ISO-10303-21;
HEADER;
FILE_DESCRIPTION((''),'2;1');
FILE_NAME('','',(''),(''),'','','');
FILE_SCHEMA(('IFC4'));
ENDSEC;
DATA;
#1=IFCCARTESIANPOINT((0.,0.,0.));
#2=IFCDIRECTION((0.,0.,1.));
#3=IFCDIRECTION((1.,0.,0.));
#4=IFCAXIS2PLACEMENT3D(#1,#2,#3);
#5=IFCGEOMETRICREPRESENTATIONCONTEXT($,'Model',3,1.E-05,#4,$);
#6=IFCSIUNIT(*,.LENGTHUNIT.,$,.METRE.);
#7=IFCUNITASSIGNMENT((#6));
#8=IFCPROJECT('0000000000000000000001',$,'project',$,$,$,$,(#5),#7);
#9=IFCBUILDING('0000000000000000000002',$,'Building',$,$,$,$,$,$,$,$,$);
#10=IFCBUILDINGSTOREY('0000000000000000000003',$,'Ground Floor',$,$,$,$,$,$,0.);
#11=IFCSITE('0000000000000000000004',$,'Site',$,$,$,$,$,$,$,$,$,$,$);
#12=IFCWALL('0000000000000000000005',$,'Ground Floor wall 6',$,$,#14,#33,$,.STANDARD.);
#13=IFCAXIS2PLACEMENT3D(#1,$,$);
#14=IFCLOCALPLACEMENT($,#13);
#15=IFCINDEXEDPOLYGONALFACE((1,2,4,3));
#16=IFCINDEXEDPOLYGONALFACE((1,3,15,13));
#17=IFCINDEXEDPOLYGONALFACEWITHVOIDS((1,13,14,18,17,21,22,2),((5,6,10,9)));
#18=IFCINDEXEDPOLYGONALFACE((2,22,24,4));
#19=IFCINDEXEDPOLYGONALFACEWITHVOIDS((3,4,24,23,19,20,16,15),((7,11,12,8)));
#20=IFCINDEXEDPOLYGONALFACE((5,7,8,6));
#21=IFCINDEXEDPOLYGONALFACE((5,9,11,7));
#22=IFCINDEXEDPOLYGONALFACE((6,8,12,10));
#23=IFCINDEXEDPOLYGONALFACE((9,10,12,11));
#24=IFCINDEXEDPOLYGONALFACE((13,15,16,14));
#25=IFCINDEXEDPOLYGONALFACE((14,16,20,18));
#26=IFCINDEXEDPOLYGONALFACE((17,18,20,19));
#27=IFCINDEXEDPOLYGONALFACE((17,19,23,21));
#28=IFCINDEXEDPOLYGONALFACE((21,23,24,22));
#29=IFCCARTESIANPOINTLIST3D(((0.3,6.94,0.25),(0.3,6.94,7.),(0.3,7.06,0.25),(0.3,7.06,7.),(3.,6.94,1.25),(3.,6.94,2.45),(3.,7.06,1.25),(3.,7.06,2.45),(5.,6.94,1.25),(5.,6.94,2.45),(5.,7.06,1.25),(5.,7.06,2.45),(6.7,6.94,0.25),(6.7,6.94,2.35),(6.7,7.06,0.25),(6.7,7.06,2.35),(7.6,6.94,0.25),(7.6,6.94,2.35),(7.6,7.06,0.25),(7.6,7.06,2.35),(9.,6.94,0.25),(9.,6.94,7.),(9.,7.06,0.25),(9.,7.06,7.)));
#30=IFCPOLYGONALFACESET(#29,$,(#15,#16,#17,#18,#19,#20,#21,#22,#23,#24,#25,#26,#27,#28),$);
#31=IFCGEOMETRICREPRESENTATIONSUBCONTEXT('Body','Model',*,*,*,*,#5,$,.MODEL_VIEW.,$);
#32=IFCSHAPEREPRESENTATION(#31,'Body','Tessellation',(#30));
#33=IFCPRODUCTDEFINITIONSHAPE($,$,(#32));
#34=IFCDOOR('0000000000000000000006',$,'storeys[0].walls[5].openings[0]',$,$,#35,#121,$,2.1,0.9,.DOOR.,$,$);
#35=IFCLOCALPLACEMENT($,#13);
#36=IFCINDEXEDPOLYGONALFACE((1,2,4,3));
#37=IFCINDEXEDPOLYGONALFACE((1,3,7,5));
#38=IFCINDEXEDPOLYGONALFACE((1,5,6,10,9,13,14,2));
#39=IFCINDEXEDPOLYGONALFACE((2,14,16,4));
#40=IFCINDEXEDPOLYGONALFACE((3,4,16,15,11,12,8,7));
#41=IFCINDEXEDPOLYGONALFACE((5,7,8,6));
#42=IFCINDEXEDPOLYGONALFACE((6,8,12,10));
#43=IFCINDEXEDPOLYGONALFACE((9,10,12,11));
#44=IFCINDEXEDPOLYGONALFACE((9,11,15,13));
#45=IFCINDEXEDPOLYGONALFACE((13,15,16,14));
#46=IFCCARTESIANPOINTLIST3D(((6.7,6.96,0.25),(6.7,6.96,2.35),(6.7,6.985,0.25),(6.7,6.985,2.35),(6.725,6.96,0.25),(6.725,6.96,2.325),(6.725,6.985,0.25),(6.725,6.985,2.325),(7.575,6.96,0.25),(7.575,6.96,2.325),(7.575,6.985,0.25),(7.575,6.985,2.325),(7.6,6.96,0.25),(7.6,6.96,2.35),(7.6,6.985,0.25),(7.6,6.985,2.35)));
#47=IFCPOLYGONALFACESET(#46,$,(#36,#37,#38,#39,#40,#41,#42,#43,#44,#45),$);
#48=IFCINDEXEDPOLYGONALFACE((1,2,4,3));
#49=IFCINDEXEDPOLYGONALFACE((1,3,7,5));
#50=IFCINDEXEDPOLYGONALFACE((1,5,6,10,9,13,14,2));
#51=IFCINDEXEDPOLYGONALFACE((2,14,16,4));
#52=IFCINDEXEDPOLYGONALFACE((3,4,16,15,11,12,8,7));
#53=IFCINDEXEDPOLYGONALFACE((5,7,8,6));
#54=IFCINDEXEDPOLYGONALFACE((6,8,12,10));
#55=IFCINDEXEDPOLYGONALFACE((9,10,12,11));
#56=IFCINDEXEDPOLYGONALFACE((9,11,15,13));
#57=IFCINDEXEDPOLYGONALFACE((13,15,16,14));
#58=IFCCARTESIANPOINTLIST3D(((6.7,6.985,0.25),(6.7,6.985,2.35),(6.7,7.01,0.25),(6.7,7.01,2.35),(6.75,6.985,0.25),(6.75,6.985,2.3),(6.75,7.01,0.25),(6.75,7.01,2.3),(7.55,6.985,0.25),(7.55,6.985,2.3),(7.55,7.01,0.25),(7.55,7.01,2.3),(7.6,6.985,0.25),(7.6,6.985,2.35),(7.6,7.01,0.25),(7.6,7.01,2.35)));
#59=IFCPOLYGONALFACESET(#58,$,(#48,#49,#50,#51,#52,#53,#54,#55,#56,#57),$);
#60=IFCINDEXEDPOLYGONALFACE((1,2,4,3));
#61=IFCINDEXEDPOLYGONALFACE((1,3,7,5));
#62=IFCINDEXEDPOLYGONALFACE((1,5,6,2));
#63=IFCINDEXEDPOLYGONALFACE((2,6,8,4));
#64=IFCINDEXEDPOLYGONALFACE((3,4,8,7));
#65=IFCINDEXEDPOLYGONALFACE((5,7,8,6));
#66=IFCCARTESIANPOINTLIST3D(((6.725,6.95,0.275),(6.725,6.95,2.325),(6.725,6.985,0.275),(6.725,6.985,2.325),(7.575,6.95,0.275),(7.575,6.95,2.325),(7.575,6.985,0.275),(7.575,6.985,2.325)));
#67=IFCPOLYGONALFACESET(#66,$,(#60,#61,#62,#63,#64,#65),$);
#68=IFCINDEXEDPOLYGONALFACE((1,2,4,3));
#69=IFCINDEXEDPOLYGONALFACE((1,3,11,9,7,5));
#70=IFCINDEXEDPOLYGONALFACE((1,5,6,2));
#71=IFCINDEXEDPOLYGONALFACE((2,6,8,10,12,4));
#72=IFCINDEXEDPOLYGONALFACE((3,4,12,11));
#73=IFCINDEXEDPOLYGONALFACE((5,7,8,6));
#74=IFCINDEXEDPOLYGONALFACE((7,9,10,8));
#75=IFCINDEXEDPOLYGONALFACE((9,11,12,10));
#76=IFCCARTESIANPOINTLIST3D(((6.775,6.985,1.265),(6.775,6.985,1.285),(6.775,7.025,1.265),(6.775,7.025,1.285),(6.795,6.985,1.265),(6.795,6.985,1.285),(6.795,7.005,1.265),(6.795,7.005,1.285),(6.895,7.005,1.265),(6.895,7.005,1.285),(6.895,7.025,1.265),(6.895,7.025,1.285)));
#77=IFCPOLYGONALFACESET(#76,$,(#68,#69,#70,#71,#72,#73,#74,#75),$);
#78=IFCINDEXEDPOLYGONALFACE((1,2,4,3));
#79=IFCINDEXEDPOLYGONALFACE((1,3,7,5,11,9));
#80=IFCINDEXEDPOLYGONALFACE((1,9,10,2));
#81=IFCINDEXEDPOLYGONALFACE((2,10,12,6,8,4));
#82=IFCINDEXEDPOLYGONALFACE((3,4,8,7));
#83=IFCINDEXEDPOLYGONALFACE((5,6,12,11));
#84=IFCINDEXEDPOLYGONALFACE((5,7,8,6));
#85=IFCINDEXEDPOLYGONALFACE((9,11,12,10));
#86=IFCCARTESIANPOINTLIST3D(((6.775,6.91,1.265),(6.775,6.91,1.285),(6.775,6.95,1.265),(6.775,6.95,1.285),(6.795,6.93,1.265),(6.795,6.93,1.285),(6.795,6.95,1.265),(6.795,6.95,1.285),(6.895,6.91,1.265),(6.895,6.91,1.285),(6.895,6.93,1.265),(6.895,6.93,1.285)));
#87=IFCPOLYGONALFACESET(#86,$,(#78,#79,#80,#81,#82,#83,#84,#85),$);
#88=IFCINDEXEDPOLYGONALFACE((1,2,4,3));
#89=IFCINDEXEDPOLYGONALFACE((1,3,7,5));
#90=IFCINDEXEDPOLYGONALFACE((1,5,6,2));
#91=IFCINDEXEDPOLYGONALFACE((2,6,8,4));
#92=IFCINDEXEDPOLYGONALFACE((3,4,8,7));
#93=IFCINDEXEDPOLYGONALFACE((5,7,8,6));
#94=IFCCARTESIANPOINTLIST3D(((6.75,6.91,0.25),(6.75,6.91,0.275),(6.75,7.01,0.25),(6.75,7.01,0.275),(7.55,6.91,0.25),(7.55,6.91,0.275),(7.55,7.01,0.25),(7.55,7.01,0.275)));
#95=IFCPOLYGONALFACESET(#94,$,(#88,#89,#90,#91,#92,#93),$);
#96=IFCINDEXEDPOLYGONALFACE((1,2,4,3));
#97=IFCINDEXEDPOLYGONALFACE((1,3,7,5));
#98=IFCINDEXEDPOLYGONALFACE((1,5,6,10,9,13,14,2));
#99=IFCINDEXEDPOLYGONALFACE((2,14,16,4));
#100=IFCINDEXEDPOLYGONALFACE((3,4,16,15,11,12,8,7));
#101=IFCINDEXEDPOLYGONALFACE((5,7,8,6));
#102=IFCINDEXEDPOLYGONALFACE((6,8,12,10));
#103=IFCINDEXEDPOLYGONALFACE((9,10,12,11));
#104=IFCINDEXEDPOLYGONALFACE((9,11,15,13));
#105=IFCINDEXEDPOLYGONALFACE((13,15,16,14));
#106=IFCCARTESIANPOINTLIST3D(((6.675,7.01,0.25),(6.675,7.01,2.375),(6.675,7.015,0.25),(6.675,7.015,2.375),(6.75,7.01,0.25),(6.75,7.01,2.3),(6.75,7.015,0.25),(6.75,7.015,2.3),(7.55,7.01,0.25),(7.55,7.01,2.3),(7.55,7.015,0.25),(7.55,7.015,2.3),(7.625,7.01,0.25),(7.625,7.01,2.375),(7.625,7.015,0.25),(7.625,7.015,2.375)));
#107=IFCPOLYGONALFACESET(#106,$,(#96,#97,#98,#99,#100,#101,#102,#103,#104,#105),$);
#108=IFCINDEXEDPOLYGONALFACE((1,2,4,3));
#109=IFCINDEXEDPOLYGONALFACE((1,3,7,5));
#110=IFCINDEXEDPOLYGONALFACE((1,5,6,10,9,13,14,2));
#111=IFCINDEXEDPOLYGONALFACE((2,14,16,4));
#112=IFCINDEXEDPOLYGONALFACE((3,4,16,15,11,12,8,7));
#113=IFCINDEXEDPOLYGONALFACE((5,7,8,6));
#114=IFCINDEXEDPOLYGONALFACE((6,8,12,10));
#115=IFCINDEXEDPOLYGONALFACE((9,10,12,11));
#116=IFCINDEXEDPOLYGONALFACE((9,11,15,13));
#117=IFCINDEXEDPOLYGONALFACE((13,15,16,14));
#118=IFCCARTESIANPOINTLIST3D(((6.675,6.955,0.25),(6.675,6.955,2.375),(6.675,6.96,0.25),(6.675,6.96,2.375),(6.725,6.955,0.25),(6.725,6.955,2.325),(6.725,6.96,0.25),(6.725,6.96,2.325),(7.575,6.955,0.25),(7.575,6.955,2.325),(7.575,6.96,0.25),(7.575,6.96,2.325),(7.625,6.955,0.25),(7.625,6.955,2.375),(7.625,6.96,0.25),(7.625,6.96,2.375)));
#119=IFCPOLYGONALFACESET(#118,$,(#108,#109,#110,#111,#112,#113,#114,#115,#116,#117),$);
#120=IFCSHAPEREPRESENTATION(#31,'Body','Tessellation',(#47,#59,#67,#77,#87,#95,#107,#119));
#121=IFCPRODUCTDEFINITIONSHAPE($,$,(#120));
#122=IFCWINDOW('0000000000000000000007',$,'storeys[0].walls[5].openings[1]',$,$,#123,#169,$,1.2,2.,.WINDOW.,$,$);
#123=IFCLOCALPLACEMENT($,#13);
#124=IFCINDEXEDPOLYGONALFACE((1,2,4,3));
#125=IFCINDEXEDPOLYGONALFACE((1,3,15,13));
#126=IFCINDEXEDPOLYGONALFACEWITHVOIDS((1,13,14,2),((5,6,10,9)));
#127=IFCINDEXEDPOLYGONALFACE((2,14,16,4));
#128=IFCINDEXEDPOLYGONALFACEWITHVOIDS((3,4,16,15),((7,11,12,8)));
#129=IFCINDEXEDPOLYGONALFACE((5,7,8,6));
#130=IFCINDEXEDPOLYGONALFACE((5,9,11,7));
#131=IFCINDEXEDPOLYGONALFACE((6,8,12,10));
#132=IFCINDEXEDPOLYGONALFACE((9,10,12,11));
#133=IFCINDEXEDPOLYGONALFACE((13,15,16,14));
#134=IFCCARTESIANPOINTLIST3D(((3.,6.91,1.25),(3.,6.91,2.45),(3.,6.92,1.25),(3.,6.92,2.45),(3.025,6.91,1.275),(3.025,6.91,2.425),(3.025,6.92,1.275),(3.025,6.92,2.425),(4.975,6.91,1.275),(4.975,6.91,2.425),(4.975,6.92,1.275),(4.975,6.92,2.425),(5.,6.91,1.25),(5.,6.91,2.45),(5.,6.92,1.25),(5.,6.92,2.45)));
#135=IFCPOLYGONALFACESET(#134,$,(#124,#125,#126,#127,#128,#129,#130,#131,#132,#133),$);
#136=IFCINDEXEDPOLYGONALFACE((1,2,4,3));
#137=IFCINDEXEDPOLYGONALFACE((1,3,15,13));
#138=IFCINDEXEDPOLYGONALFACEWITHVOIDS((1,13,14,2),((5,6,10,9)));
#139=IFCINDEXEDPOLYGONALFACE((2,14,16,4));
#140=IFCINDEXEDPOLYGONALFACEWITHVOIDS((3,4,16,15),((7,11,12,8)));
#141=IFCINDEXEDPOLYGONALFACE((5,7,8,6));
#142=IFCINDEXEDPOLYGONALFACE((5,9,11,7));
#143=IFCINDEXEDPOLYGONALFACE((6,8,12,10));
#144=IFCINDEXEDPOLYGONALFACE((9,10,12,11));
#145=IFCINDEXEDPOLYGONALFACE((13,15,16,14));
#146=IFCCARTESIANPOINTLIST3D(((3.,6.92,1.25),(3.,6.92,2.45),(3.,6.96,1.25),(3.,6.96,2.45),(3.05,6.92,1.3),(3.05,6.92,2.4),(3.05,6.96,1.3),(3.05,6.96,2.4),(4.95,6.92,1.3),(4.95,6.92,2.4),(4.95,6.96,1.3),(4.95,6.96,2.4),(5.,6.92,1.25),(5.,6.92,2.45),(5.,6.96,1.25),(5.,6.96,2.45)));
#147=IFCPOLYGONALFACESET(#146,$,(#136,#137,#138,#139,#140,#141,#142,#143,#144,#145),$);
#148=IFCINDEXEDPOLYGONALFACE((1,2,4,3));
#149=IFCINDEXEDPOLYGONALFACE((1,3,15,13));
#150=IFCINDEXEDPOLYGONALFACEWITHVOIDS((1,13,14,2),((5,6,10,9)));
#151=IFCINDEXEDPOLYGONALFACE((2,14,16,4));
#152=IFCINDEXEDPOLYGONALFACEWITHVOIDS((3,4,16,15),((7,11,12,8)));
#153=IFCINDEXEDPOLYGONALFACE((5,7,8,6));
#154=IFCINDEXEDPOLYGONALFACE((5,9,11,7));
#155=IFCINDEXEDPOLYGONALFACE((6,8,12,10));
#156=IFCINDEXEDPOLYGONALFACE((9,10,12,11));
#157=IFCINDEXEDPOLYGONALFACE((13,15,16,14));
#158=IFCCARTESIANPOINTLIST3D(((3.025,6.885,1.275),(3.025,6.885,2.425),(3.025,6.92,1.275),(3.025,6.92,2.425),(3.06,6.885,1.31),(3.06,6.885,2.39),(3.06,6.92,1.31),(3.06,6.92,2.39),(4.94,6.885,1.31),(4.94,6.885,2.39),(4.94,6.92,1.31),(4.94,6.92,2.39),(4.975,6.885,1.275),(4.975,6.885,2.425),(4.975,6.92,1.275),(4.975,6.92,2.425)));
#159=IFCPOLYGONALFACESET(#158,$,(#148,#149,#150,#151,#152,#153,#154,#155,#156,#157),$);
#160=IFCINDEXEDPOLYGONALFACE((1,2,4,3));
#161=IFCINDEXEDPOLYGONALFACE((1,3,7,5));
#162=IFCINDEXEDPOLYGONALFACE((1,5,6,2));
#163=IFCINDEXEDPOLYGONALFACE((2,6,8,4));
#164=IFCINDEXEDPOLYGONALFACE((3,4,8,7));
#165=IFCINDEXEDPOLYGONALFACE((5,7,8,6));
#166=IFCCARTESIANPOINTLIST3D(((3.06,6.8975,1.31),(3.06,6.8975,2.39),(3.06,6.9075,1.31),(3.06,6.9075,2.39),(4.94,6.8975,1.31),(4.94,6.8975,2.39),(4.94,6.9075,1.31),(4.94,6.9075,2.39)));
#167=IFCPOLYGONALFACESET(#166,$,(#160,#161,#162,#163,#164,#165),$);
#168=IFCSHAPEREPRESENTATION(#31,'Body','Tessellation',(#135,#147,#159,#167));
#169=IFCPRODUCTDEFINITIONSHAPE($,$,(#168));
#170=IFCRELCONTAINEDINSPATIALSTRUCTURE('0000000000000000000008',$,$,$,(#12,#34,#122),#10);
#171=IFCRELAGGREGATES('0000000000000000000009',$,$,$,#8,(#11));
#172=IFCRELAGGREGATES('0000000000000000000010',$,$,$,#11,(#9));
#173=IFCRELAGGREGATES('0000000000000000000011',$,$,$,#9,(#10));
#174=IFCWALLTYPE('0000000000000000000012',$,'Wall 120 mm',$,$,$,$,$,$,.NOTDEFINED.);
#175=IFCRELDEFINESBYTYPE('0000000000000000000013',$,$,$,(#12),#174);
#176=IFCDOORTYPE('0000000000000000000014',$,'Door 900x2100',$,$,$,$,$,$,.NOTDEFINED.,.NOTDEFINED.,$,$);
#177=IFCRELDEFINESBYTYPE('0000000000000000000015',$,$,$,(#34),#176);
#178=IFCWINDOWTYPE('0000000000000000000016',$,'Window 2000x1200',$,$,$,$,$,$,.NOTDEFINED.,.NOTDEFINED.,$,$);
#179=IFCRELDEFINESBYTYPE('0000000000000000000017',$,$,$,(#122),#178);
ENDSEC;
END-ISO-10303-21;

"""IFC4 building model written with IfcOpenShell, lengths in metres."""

from ifc_helpers import new_model, si_unit, frame, origin_with_axes, place, context, subcontext, project, spatial, line, indexed_curve, outline, extrude, type_object, element, fill, save


model = new_model("IFC4")

# Units and contexts
model_context = context("Model", 3, precision=1e-05, world=origin_with_axes())
body_context = subcontext(model_context, "Body", "Model", "MODEL_VIEW")
ifc_project = project(units=[si_unit("LENGTHUNIT", "METRE")], contexts=[model_context])

# Site, building, storey
site = spatial("IfcSite", under=ifc_project, Name="Site")
building = spatial("IfcBuilding", under=site, Name="Building")
storey = spatial("IfcBuildingStorey", under=building, Name="Ground Floor", Elevation=0.0)

# Shared definitions
wall_type_1 = type_object("IfcWallType", Name="Wall 120 mm", PredefinedType="NOTDEFINED")
door_type_1 = type_object("IfcDoorType", Name="Door 900x2100", OperationType="NOTDEFINED", PredefinedType="NOTDEFINED")

# Wall, openings, door, window
wall_1_placement = place(None, frame((9.0, 7.0, 0.25), z_axis=(0.0, 0.0, 1.0), x_axis=(-1.0, 0.0, 0.0)))
wall_1 = element("IfcWall", 1, at=wall_1_placement, inside=storey, type_object=wall_type_1, Name="Ground Floor wall 6", PredefinedType="STANDARD", context=body_context, shape_type="SweptSolid", body=[
    extrude(outline(indexed_curve([(0.0, 0.0), (0.0, 0.12), (8.7, 0.12), (8.7, 0.0), (0.0, 0.0)], self_intersect=False)), frame((0.0, -0.06, 0.0), z_axis=(0.0, 0.0, 1.0), x_axis=(1.0, 0.0, 0.0)), (0.0, 0.0, 1.0), 6.75),
])
opening_1_placement = place(wall_1_placement, frame((1.4, -0.07, 0.0), z_axis=(0.0, 0.0, 1.0), x_axis=(1.0, 0.0, 0.0)))
opening_1 = element("IfcOpeningElement", 2, at=opening_1_placement, cuts=wall_1, context=body_context, shape_type="SweptSolid", body=[
    extrude(outline(indexed_curve([(0.0, 0.0), (0.0, 0.14), (0.9, 0.14), (0.9, 0.0), (0.0, 0.0)], self_intersect=False)), origin_with_axes(), (0.0, 0.0, 1.0), 2.1),
])
opening_2_placement = place(wall_1_placement, frame((4.0, -0.07, 1.0), z_axis=(0.0, 0.0, 1.0), x_axis=(1.0, 0.0, 0.0)))
opening_2 = element("IfcOpeningElement", 3, at=opening_2_placement, cuts=wall_1, context=body_context, shape_type="SweptSolid", body=[
    extrude(outline(indexed_curve([(0.0, 0.0), (0.0, 0.14), (2.0, 0.14), (2.0, 0.0), (0.0, 0.0)], self_intersect=False)), origin_with_axes(), (0.0, 0.0, 1.0), 1.2),
])
door_1_placement = place(None, frame((7.6, 7.01, 0.25), z_axis=(0.0, 0.0, 1.0), x_axis=(-1.0, 0.0, 0.0)))
door_1 = element("IfcDoor", 4, at=door_1_placement, inside=storey, type_object=door_type_1, Name="storeys[0].walls[5].openings[0]", OverallHeight=2.1, OverallWidth=0.9, PredefinedType="DOOR", context=body_context, shape_type="SweptSolid", body=[
    extrude(outline(indexed_curve([(0.0, 0.0), (0.0, 2.1), (0.9, 2.1), (0.9, 0.0), (0.875, 0.0), (0.875, 2.075), (0.025, 2.075), (0.025, 0.0)], segments=[line(1, 2, 3, 4, 5, 6, 7, 8, 1)])), frame((0.0, 0.025, 0.0), z_axis=(0.0, -1.0, 0.0), x_axis=(1.0, 0.0, 0.0)), (0.0, 0.0, -1.0), 0.025),
    extrude(outline(indexed_curve([(0.0, 0.0), (0.0, 2.1), (0.9, 2.1), (0.9, 0.0), (0.85, 0.0), (0.85, 2.05), (0.05, 2.05), (0.05, 0.0)], segments=[line(1, 2, 3, 4, 5, 6, 7, 8, 1)])), frame((0.0, 0.0, 0.0), z_axis=(0.0, -1.0, 0.0), x_axis=(1.0, 0.0, 0.0)), (0.0, 0.0, -1.0), 0.025),
    extrude(outline(indexed_curve([(0.0, 0.0), (0.85, 0.0), (0.85, 0.035), (0.0, 0.035)], segments=[line(1, 2, 3, 4, 1)])), frame((0.025, 0.025, 0.025), z_axis=(0.0, 0.0, 1.0), x_axis=(1.0, 0.0, 0.0)), (0.0, 0.0, 1.0), 2.05),
    extrude(outline(indexed_curve([(0.0, 0.0), (0.0, -0.04), (-0.12, -0.04), (-0.12, -0.02), (-0.02, -0.02), (-0.02, 0.0)], segments=[line(1, 2, 3, 4, 5, 6, 1)])), frame((0.825, 0.025, 1.015), z_axis=(0.0, 0.0, 1.0), x_axis=(1.0, 0.0, 0.0)), (0.0, 0.0, 1.0), 0.02),
    extrude(outline(indexed_curve([(0.0, 0.0), (0.0, 0.04), (-0.12, 0.04), (-0.12, 0.02), (-0.02, 0.02), (-0.02, 0.0)], segments=[line(1, 2, 3, 4, 5, 6, 1)])), frame((0.825, 0.06, 1.015), z_axis=(0.0, 0.0, 1.0), x_axis=(1.0, 0.0, 0.0)), (0.0, 0.0, 1.0), 0.02),
    extrude(outline(indexed_curve([(0.0, 0.0), (0.8, 0.0), (0.8, 0.1), (0.0, 0.1)], segments=[line(1, 2, 3, 4, 1)])), frame((0.05, 0.0, 0.0), z_axis=(0.0, 0.0, 1.0), x_axis=(1.0, 0.0, 0.0)), (0.0, 0.0, 1.0), 0.025),
    extrude(outline(indexed_curve([(0.0, 0.0), (0.0, 2.125), (0.95, 2.125), (0.95, 0.0), (0.875, 0.0), (0.875, 2.05), (0.075, 2.05), (0.075, 0.0)], segments=[line(1, 2, 3, 4, 5, 6, 7, 8, 1)])), frame((-0.025, -0.005, 0.0), z_axis=(0.0, -1.0, 0.0), x_axis=(1.0, 0.0, 0.0)), (0.0, 0.0, -1.0), 0.005),
    extrude(outline(indexed_curve([(0.0, 0.0), (0.0, 2.125), (0.95, 2.125), (0.95, 0.0), (0.9, 0.0), (0.9, 2.075), (0.05, 2.075), (0.05, 0.0)], segments=[line(1, 2, 3, 4, 5, 6, 7, 8, 1)])), frame((-0.025, 0.05, 0.0), z_axis=(0.0, -1.0, 0.0), x_axis=(1.0, 0.0, 0.0)), (0.0, 0.0, -1.0), 0.005),
])
fill(opening_1, door_1)
window_type_1 = type_object("IfcWindowType", Name="Window 2000x1200", PartitioningType="NOTDEFINED", PredefinedType="NOTDEFINED")
window_1_placement = place(None, frame((5.0, 7.01, 1.25), z_axis=(0.0, 0.0, 1.0), x_axis=(-1.0, 0.0, 0.0)))
window_1 = element("IfcWindow", 5, at=window_1_placement, inside=storey, type_object=window_type_1, Name="storeys[0].walls[5].openings[1]", OverallHeight=1.2, OverallWidth=2.0, PredefinedType="WINDOW", context=body_context, shape_type="SweptSolid", body=[
    extrude(outline(indexed_curve([(0.0, 0.0), (2.0, 0.0), (2.0, 1.2), (0.0, 1.2)], segments=[line(1, 2, 3, 4, 1)]), holes=[indexed_curve([(0.025, 0.025), (1.975, 0.025), (1.975, 1.175), (0.025, 1.175)], segments=[line(1, 2, 3, 4, 1)])]), frame((0.0, 0.09, 0.0), z_axis=(0.0, -1.0, 0.0), x_axis=(1.0, 0.0, 0.0)), (0.0, 0.0, -1.0), 0.01),
    extrude(outline(indexed_curve([(0.0, 0.0), (2.0, 0.0), (2.0, 1.2), (0.0, 1.2)], segments=[line(1, 2, 3, 4, 1)]), holes=[indexed_curve([(0.05, 0.05), (1.95, 0.05), (1.95, 1.15), (0.05, 1.15)], segments=[line(1, 2, 3, 4, 1)])]), frame((0.0, 0.05, 0.0), z_axis=(0.0, -1.0, 0.0), x_axis=(1.0, 0.0, 0.0)), (0.0, 0.0, -1.0), 0.04),
    extrude(outline(indexed_curve([(0.0, 0.0), (1.95, 0.0), (1.95, 1.15), (0.0, 1.15)], segments=[line(1, 2, 3, 4, 1)]), holes=[indexed_curve([(0.035, 0.035), (1.915, 0.035), (1.915, 1.115), (0.035, 1.115)], segments=[line(1, 2, 3, 4, 1)])]), frame((0.025, 0.09, 0.025), z_axis=(0.0, -1.0, 0.0), x_axis=(1.0, 0.0, 0.0)), (0.0, 0.0, -1.0), 0.035),
    extrude(outline(indexed_curve([(0.035, 0.035), (1.915, 0.035), (1.915, 1.115), (0.035, 1.115)], segments=[line(1, 2, 3, 4, 1)])), frame((0.025, 0.1025, 0.025), z_axis=(0.0, -1.0, 0.0), x_axis=(1.0, 0.0, 0.0)), (0.0, 0.0, -1.0), 0.01),
])
fill(opening_2, window_1)

save(model, "model.ifc")
